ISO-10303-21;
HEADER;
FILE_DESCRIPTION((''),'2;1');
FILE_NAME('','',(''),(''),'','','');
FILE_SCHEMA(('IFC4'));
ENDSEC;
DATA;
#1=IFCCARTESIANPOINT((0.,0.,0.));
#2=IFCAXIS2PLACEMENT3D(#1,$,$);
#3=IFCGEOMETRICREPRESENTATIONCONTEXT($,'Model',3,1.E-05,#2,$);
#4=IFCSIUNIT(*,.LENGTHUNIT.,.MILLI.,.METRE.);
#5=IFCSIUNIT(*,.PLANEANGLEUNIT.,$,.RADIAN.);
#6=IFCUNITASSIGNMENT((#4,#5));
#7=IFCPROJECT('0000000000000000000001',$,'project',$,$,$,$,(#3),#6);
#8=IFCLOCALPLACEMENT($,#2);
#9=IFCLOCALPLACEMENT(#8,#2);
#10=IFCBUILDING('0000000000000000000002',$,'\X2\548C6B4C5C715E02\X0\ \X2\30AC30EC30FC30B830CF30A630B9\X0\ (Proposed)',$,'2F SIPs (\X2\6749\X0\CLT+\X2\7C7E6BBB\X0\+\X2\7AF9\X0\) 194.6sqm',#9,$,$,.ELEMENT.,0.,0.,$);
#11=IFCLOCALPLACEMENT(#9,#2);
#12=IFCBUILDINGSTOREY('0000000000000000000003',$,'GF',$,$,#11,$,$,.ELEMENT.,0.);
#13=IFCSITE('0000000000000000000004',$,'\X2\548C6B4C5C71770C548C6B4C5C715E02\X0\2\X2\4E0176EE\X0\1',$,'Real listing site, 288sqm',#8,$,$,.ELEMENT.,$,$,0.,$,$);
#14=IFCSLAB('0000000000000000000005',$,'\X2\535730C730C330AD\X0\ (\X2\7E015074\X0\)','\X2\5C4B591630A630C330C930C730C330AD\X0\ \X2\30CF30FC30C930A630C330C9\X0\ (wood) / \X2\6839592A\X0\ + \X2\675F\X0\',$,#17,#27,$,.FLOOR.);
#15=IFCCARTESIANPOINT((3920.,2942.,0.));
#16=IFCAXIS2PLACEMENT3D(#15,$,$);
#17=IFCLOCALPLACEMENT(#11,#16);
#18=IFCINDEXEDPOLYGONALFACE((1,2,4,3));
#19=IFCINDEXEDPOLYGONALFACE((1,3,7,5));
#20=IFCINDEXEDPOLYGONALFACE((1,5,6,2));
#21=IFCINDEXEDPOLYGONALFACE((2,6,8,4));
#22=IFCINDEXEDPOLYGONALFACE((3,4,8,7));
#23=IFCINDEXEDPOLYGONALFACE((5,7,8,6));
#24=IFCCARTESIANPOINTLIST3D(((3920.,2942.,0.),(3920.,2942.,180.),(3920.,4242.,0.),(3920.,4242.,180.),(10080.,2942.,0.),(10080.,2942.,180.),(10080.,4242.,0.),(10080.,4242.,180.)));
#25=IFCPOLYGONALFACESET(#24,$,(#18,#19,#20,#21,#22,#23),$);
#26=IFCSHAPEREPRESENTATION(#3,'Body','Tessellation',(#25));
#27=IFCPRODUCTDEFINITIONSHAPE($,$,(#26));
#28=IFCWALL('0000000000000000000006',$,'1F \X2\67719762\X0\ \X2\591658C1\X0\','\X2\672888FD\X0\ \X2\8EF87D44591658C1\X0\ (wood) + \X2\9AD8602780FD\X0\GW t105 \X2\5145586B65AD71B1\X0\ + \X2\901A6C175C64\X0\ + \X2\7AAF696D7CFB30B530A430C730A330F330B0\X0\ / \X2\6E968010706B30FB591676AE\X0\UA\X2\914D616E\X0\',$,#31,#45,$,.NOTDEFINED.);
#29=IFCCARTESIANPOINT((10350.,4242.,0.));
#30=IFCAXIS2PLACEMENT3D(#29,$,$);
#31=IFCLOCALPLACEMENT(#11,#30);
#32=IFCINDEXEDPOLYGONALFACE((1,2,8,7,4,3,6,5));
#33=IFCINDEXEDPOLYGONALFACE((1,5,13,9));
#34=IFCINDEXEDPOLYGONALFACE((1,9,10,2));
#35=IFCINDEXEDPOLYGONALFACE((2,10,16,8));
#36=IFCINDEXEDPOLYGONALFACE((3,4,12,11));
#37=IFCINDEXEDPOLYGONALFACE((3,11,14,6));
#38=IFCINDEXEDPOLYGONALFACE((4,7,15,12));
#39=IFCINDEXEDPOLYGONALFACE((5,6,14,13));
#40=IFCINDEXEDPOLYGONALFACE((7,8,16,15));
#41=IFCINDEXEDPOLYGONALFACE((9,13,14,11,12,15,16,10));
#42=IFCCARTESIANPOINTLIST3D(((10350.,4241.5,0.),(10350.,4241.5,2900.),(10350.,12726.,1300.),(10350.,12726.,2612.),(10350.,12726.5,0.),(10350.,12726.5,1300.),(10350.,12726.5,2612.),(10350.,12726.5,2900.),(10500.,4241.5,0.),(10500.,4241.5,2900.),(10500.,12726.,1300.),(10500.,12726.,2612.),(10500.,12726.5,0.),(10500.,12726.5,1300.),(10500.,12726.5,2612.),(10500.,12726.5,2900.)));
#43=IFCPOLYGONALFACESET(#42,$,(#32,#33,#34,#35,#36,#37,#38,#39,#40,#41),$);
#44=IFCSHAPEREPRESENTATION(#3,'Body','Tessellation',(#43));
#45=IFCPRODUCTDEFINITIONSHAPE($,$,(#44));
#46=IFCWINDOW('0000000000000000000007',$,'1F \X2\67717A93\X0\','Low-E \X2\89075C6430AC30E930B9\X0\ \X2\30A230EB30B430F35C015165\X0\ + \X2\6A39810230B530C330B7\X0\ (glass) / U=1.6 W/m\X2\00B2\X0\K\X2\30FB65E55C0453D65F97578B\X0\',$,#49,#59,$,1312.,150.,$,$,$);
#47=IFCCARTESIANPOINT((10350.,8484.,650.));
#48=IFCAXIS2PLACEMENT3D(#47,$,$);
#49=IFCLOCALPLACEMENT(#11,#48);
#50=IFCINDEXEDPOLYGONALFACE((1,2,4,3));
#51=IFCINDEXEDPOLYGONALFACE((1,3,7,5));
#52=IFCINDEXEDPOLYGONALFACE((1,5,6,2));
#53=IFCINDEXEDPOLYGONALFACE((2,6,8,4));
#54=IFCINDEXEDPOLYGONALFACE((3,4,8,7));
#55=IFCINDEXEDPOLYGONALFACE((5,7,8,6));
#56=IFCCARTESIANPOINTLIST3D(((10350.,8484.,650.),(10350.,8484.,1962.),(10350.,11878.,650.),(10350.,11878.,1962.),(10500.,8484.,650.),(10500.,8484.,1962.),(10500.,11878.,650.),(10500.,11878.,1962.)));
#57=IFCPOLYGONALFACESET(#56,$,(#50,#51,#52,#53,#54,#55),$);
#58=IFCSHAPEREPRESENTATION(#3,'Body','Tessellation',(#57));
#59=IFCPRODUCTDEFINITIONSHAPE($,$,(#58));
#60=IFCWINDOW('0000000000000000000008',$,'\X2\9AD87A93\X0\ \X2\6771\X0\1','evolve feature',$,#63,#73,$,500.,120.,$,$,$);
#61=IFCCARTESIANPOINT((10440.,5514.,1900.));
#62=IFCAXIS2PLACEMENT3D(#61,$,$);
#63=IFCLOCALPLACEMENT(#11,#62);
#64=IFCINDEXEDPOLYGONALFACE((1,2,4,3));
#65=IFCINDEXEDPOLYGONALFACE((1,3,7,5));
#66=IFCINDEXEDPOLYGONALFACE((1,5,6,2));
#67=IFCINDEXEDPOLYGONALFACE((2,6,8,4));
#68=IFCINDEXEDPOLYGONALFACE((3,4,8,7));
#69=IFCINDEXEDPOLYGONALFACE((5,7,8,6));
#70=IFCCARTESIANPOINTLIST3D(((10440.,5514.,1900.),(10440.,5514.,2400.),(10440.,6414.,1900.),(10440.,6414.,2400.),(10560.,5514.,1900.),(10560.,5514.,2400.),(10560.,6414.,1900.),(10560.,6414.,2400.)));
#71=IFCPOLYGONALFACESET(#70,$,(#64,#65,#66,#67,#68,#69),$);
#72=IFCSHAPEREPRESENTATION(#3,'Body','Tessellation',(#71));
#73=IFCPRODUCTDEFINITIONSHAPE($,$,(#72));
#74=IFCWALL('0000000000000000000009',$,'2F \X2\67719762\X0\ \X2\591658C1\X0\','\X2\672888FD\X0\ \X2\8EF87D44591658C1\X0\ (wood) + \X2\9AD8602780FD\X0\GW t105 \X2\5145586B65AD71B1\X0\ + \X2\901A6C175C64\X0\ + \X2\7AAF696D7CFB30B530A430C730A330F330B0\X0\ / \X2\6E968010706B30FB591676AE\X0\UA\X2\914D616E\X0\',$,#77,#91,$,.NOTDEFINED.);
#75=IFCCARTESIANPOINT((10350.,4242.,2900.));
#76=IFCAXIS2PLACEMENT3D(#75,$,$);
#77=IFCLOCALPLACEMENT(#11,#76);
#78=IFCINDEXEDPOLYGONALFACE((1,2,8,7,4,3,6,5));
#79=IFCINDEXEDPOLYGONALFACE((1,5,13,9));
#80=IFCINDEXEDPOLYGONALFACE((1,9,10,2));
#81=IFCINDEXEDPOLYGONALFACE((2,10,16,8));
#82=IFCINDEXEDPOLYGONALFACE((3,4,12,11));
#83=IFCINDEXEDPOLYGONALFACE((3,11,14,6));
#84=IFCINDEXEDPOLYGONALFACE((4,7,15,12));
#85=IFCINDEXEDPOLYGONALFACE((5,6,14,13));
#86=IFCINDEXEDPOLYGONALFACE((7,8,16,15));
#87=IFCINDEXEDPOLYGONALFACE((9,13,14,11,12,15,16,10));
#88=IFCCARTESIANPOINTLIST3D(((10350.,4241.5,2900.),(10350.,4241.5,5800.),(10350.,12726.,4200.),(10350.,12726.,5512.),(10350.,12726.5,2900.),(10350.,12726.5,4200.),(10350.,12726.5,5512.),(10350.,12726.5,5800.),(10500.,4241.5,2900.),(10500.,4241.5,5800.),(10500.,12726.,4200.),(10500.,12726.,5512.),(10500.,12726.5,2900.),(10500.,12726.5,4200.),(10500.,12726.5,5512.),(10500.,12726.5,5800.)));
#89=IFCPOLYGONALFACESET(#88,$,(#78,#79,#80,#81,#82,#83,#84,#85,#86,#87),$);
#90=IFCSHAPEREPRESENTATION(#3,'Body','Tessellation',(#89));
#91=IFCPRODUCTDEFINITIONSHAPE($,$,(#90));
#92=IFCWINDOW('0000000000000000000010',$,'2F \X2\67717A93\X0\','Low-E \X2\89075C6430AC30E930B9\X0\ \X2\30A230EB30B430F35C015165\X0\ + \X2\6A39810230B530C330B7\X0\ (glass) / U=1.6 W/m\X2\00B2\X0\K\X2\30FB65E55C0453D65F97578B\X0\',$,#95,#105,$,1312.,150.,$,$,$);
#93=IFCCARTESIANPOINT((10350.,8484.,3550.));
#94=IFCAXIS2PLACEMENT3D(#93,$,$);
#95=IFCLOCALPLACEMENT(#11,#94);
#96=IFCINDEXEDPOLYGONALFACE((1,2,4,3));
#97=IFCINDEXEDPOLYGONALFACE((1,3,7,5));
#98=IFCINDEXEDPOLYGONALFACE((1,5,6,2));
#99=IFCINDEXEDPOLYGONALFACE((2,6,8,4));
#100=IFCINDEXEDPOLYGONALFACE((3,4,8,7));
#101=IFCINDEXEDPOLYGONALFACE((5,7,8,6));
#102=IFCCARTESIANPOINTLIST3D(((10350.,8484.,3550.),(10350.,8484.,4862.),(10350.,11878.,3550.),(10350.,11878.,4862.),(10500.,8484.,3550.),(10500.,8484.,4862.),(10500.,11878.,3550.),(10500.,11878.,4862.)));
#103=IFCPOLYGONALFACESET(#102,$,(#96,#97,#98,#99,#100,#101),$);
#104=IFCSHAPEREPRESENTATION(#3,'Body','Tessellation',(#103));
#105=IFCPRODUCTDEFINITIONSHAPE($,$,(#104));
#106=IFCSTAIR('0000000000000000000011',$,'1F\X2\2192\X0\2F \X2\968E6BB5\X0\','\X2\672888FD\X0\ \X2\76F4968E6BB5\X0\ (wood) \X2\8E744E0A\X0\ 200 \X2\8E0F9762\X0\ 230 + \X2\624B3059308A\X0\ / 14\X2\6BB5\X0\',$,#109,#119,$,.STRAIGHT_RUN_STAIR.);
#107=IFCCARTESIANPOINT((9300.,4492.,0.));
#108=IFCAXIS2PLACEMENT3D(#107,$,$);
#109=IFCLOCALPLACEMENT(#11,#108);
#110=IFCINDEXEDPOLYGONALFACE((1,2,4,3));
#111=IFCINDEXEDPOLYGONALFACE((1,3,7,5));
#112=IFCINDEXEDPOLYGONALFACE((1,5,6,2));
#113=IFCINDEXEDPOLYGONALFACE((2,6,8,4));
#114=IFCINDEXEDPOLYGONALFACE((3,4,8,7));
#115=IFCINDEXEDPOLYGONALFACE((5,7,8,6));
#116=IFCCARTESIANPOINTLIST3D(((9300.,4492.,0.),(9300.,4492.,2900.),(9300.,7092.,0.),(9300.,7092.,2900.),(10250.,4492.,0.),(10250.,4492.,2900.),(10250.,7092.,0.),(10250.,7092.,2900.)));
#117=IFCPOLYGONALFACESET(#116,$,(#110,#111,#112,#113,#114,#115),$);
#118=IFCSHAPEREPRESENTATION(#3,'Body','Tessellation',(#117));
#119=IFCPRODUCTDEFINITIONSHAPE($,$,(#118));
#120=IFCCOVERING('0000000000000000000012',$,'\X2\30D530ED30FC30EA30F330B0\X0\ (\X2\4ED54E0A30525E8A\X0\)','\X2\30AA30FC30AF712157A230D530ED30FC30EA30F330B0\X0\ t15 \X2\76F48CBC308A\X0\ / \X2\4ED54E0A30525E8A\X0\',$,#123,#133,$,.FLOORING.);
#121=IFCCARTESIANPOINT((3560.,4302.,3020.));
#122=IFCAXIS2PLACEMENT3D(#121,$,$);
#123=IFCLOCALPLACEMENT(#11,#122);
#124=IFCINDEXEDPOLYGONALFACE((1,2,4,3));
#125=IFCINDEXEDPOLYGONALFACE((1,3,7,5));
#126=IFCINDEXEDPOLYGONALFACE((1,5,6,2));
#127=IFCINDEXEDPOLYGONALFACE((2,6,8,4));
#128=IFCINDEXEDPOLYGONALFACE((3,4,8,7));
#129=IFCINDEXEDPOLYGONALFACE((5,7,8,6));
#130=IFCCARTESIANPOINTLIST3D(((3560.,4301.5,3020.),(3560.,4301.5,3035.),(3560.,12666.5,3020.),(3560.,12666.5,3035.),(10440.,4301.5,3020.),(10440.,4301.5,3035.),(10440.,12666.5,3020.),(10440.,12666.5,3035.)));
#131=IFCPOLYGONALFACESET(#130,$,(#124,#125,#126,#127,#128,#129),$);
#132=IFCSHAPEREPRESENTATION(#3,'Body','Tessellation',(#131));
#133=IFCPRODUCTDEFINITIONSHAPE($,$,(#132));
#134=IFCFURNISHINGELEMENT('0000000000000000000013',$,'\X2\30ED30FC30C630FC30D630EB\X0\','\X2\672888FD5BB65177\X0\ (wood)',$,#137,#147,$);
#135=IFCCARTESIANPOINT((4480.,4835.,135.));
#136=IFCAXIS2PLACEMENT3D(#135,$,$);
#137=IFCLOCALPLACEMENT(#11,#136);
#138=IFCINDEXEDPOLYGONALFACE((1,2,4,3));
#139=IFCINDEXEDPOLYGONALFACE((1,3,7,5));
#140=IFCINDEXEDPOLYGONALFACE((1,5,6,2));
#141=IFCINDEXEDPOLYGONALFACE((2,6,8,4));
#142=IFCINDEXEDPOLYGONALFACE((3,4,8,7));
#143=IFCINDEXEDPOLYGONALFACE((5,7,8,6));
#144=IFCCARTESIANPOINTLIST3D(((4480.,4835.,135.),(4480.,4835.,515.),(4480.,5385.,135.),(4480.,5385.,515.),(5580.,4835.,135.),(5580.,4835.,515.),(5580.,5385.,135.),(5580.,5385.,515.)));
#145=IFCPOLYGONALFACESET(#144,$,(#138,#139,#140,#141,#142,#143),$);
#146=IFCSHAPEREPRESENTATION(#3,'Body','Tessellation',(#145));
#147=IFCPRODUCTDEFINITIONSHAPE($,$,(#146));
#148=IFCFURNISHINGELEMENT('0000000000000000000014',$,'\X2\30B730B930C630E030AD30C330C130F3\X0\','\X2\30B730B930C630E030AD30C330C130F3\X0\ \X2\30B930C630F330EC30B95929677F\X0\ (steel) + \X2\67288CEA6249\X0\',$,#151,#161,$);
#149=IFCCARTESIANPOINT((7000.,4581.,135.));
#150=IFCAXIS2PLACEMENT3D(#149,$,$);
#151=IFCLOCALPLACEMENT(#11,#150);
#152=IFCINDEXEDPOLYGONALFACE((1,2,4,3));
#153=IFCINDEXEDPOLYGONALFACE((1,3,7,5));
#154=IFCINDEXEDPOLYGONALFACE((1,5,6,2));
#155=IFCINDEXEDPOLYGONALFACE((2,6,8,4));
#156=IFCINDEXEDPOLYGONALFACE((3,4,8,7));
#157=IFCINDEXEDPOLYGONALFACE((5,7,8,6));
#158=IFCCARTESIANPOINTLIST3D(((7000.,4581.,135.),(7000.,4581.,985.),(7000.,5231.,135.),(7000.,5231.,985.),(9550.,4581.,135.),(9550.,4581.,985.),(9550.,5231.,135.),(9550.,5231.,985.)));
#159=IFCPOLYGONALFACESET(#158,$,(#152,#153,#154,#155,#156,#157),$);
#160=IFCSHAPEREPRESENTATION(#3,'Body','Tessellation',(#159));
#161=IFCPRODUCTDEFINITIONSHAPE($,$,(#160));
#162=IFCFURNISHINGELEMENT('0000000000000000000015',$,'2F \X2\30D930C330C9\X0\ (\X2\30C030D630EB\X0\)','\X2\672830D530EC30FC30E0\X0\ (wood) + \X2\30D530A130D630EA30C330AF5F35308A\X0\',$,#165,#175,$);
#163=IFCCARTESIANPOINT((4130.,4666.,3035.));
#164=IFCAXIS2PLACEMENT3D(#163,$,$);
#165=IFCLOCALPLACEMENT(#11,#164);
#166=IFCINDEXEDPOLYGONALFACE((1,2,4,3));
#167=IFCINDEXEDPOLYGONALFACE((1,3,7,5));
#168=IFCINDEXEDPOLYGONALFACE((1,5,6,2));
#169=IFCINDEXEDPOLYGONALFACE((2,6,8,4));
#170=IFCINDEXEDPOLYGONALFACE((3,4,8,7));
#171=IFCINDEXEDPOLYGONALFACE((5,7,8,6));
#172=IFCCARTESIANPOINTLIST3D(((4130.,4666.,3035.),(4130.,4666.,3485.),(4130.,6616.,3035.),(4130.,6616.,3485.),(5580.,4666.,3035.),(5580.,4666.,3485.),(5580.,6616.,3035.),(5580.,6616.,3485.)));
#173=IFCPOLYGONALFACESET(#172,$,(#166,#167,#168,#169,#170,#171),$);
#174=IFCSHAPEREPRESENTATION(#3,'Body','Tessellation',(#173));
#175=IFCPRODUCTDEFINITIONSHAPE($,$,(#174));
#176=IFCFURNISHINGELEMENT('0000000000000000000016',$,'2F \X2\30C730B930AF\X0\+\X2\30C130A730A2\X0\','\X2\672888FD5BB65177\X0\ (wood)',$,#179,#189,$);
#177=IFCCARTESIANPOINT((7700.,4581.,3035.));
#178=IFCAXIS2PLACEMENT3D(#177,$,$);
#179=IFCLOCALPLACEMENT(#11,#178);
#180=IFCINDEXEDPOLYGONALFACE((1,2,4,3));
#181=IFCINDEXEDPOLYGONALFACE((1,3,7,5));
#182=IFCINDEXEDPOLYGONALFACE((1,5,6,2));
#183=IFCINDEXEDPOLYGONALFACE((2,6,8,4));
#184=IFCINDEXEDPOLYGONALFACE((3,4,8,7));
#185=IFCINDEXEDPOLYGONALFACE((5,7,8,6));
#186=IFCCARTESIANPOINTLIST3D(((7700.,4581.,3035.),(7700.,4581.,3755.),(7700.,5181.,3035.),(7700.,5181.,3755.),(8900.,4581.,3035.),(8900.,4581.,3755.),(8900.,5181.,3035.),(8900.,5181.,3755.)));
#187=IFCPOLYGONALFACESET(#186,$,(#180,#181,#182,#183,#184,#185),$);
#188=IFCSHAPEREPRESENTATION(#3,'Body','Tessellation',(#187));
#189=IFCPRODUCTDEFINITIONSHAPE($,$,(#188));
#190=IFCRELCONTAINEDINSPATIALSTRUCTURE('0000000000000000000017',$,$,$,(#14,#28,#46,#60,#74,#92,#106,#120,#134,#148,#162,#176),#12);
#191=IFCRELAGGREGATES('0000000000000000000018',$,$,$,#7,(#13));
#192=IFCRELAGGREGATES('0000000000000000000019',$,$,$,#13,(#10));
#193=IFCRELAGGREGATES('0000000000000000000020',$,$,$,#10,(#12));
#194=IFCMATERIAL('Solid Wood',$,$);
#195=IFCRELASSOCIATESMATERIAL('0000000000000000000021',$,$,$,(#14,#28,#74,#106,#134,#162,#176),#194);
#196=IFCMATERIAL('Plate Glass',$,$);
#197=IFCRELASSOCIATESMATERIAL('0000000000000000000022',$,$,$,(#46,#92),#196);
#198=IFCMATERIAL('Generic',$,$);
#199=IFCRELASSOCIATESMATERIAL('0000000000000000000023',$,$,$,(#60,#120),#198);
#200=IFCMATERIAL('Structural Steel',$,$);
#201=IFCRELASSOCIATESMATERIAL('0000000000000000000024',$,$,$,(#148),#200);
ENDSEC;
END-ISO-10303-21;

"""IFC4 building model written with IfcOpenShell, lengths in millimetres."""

from ifc_helpers import new_model, si_unit, frame, frame_2d, origin, place, context, project, spatial, rectangle, extrude, material, element, fill, save


model = new_model("IFC4")

# Units and contexts
model_context = context("Model", 3, precision=1e-05, world=origin())
ifc_project = project(units=[si_unit("LENGTHUNIT", "METRE", prefix="MILLI"), si_unit("PLANEANGLEUNIT", "RADIAN")], contexts=[model_context])

# Site, building, storey
site_placement = place(None, origin())
site = spatial("IfcSite", under=ifc_project, at=site_placement, Name="和歌山県和歌山市2丁目1", ObjectType="Real listing site, 288sqm", CompositionType="ELEMENT", RefElevation=0.0)
building_placement = place(site_placement, origin())
building = spatial("IfcBuilding", under=site, at=building_placement, Name="和歌山市 ガレージハウス (Proposed)", ObjectType="2F SIPs (杉CLT+籾殻+竹) 194.6sqm", CompositionType="ELEMENT", ElevationOfRefHeight=0.0, ElevationOfTerrain=0.0)
storey_placement = place(building_placement, origin())
storey = spatial("IfcBuildingStorey", under=building, at=storey_placement, Name="GF", CompositionType="ELEMENT", Elevation=0.0)

# Slab
ifc_material_1 = material(Name="Solid Wood")
slab_placement = place(storey_placement, frame((3920.0, 2942.0, 0.0)))
element("IfcSlab", 1, at=slab_placement, inside=storey, material=ifc_material_1, Name="南デッキ (縁側)", Description="屋外ウッドデッキ ハードウッド (wood) / 根太 + 束", PredefinedType="FLOOR", context=model_context, shape_type="SweptSolid", body=[
    extrude(rectangle(XDim=6160.0, YDim=1300.0, at=frame_2d((3080.0, 650.0))), frame((3920.0, 2942.0, 0.0)), (0.0, 0.0, 1.0), 180.0),
])

# Wall, openings, windows
wall_1_placement = place(storey_placement, frame((10350.0, 4242.0, 0.0)))
wall_1 = element("IfcWall", 2, at=wall_1_placement, inside=storey, material=ifc_material_1, Name="1F 東面 外壁", Description="木製 軸組外壁 (wood) + 高性能GW t105 充填断熱 + 通気層 + 窯業系サイディング / 準耐火・外皮UA配慮", PredefinedType="NOTDEFINED", context=model_context, shape_type="SweptSolid", body=[
    extrude(rectangle(XDim=150.0, YDim=8485.0, at=frame_2d((75.0, 4242.0))), frame((10350.0, 4242.0, 0.0)), (0.0, 0.0, 1.0), 2900.0),
])
opening_1_placement = place(storey_placement, frame((10350.0, 8484.0, 650.0)))
opening_1 = element("IfcOpeningElement", 3, at=opening_1_placement, cuts=wall_1, PredefinedType="NOTDEFINED", context=model_context, shape_type="SweptSolid", body=[
    extrude(rectangle(XDim=150.0, YDim=3394.0, at=frame_2d((75.0, 1697.0))), frame((10350.0, 8484.0, 650.0)), (0.0, 0.0, 1.0), 1312.0),
])
opening_2_placement = place(storey_placement, frame((10440.0, 5514.0, 1900.0)))
opening_2 = element("IfcOpeningElement", 4, at=opening_2_placement, cuts=wall_1, PredefinedType="NOTDEFINED", context=model_context, shape_type="SweptSolid", body=[
    extrude(rectangle(XDim=120.0, YDim=900.0, at=frame_2d((60.0, 450.0))), frame((10440.0, 5514.0, 1900.0)), (0.0, 0.0, 1.0), 500.0),
])
ifc_material_2 = material(Name="Plate Glass")
window_1_placement = place(storey_placement, frame((10350.0, 8484.0, 650.0)))
window_1 = element("IfcWindow", 5, at=window_1_placement, inside=storey, material=ifc_material_2, Name="1F 東窓", Description="Low-E 複層ガラス アルゴン封入 + 樹脂サッシ (glass) / U=1.6 W/m²K・日射取得型", OverallHeight=1312.0, OverallWidth=150.0, context=model_context, shape_type="SweptSolid", body=[
    extrude(rectangle(XDim=150.0, YDim=3394.0, at=frame_2d((75.0, 1697.0))), frame((10350.0, 8484.0, 650.0)), (0.0, 0.0, 1.0), 1312.0),
])
fill(opening_1, window_1)
ifc_material_3 = material(Name="Generic")
window_2_placement = place(storey_placement, frame((10440.0, 5514.0, 1900.0)))
window_2 = element("IfcWindow", 6, at=window_2_placement, inside=storey, material=ifc_material_3, Name="高窓 東1", Description="evolve feature", OverallHeight=500.0, OverallWidth=120.0, context=model_context, shape_type="SweptSolid", body=[
    extrude(rectangle(XDim=120.0, YDim=900.0, at=frame_2d((60.0, 450.0))), frame((10440.0, 5514.0, 1900.0)), (0.0, 0.0, 1.0), 500.0),
])
fill(opening_2, window_2)

# Wall, opening, window
wall_2_placement = place(storey_placement, frame((10350.0, 4242.0, 2900.0)))
wall_2 = element("IfcWall", 7, at=wall_2_placement, inside=storey, material=ifc_material_1, Name="2F 東面 外壁", Description="木製 軸組外壁 (wood) + 高性能GW t105 充填断熱 + 通気層 + 窯業系サイディング / 準耐火・外皮UA配慮", PredefinedType="NOTDEFINED", context=model_context, shape_type="SweptSolid", body=[
    extrude(rectangle(XDim=150.0, YDim=8485.0, at=frame_2d((75.0, 4242.0))), frame((10350.0, 4242.0, 2900.0)), (0.0, 0.0, 1.0), 2900.0),
])
opening_3_placement = place(storey_placement, frame((10350.0, 8484.0, 3550.0)))
opening_3 = element("IfcOpeningElement", 8, at=opening_3_placement, cuts=wall_2, PredefinedType="NOTDEFINED", context=model_context, shape_type="SweptSolid", body=[
    extrude(rectangle(XDim=150.0, YDim=3394.0, at=frame_2d((75.0, 1697.0))), frame((10350.0, 8484.0, 3550.0)), (0.0, 0.0, 1.0), 1312.0),
])
window_3_placement = place(storey_placement, frame((10350.0, 8484.0, 3550.0)))
window_3 = element("IfcWindow", 9, at=window_3_placement, inside=storey, material=ifc_material_2, Name="2F 東窓", Description="Low-E 複層ガラス アルゴン封入 + 樹脂サッシ (glass) / U=1.6 W/m²K・日射取得型", OverallHeight=1312.0, OverallWidth=150.0, context=model_context, shape_type="SweptSolid", body=[
    extrude(rectangle(XDim=150.0, YDim=3394.0, at=frame_2d((75.0, 1697.0))), frame((10350.0, 8484.0, 3550.0)), (0.0, 0.0, 1.0), 1312.0),
])
fill(opening_3, window_3)

# Stair
stair_placement = place(storey_placement, frame((9300.0, 4492.0, 0.0)))
element("IfcStair", 10, at=stair_placement, inside=storey, material=ifc_material_1, Name="1F→2F 階段", Description="木製 直階段 (wood) 蹴上 200 踏面 230 + 手すり / 14段", PredefinedType="STRAIGHT_RUN_STAIR", context=model_context, shape_type="SweptSolid", body=[
    extrude(rectangle(XDim=950.0, YDim=2600.0, at=frame_2d((475.0, 1300.0))), frame((9300.0, 4492.0, 0.0)), (0.0, 0.0, 1.0), 2900.0),
])

# Covering
covering_placement = place(storey_placement, frame((3560.0, 4302.0, 3020.0)))
element("IfcCovering", 11, at=covering_placement, inside=storey, material=ifc_material_3, Name="フローリング (仕上げ床)", Description="オーク無垢フローリング t15 直貼り / 仕上げ床", PredefinedType="FLOORING", context=model_context, shape_type="SweptSolid", body=[
    extrude(rectangle(XDim=6880.0, YDim=8365.0, at=frame_2d((3440.0, 4182.0))), frame((3560.0, 4302.0, 3020.0)), (0.0, 0.0, 1.0), 15.0),
])

# Furnishing elements
furnishing_1_placement = place(storey_placement, frame((4480.0, 4835.0, 135.0)))
element("IfcFurnishingElement", 12, at=furnishing_1_placement, inside=storey, material=ifc_material_1, Name="ローテーブル", Description="木製家具 (wood)", context=model_context, shape_type="SweptSolid", body=[
    extrude(rectangle(XDim=1100.0, YDim=550.0, at=frame_2d((550.0, 275.0))), frame((4480.0, 4835.0, 135.0)), (0.0, 0.0, 1.0), 380.0),
])
ifc_material_4 = material(Name="Structural Steel")
furnishing_2_placement = place(storey_placement, frame((7000.0, 4581.0, 135.0)))
element("IfcFurnishingElement", 13, at=furnishing_2_placement, inside=storey, material=ifc_material_4, Name="システムキッチン", Description="システムキッチン ステンレス天板 (steel) + 木質扉", context=model_context, shape_type="SweptSolid", body=[
    extrude(rectangle(XDim=2550.0, YDim=650.0, at=frame_2d((1275.0, 325.0))), frame((7000.0, 4581.0, 135.0)), (0.0, 0.0, 1.0), 850.0),
])
furnishing_3_placement = place(storey_placement, frame((4130.0, 4666.0, 3035.0)))
element("IfcFurnishingElement", 14, at=furnishing_3_placement, inside=storey, material=ifc_material_1, Name="2F ベッド (ダブル)", Description="木フレーム (wood) + ファブリック張り", context=model_context, shape_type="SweptSolid", body=[
    extrude(rectangle(XDim=1450.0, YDim=1950.0, at=frame_2d((725.0, 975.0))), frame((4130.0, 4666.0, 3035.0)), (0.0, 0.0, 1.0), 450.0),
])
furnishing_4_placement = place(storey_placement, frame((7700.0, 4581.0, 3035.0)))
element("IfcFurnishingElement", 15, at=furnishing_4_placement, inside=storey, material=ifc_material_1, Name="2F デスク+チェア", Description="木製家具 (wood)", context=model_context, shape_type="SweptSolid", body=[
    extrude(rectangle(XDim=1200.0, YDim=600.0, at=frame_2d((600.0, 300.0))), frame((7700.0, 4581.0, 3035.0)), (0.0, 0.0, 1.0), 720.0),
])

save(model, "model.ifc")
